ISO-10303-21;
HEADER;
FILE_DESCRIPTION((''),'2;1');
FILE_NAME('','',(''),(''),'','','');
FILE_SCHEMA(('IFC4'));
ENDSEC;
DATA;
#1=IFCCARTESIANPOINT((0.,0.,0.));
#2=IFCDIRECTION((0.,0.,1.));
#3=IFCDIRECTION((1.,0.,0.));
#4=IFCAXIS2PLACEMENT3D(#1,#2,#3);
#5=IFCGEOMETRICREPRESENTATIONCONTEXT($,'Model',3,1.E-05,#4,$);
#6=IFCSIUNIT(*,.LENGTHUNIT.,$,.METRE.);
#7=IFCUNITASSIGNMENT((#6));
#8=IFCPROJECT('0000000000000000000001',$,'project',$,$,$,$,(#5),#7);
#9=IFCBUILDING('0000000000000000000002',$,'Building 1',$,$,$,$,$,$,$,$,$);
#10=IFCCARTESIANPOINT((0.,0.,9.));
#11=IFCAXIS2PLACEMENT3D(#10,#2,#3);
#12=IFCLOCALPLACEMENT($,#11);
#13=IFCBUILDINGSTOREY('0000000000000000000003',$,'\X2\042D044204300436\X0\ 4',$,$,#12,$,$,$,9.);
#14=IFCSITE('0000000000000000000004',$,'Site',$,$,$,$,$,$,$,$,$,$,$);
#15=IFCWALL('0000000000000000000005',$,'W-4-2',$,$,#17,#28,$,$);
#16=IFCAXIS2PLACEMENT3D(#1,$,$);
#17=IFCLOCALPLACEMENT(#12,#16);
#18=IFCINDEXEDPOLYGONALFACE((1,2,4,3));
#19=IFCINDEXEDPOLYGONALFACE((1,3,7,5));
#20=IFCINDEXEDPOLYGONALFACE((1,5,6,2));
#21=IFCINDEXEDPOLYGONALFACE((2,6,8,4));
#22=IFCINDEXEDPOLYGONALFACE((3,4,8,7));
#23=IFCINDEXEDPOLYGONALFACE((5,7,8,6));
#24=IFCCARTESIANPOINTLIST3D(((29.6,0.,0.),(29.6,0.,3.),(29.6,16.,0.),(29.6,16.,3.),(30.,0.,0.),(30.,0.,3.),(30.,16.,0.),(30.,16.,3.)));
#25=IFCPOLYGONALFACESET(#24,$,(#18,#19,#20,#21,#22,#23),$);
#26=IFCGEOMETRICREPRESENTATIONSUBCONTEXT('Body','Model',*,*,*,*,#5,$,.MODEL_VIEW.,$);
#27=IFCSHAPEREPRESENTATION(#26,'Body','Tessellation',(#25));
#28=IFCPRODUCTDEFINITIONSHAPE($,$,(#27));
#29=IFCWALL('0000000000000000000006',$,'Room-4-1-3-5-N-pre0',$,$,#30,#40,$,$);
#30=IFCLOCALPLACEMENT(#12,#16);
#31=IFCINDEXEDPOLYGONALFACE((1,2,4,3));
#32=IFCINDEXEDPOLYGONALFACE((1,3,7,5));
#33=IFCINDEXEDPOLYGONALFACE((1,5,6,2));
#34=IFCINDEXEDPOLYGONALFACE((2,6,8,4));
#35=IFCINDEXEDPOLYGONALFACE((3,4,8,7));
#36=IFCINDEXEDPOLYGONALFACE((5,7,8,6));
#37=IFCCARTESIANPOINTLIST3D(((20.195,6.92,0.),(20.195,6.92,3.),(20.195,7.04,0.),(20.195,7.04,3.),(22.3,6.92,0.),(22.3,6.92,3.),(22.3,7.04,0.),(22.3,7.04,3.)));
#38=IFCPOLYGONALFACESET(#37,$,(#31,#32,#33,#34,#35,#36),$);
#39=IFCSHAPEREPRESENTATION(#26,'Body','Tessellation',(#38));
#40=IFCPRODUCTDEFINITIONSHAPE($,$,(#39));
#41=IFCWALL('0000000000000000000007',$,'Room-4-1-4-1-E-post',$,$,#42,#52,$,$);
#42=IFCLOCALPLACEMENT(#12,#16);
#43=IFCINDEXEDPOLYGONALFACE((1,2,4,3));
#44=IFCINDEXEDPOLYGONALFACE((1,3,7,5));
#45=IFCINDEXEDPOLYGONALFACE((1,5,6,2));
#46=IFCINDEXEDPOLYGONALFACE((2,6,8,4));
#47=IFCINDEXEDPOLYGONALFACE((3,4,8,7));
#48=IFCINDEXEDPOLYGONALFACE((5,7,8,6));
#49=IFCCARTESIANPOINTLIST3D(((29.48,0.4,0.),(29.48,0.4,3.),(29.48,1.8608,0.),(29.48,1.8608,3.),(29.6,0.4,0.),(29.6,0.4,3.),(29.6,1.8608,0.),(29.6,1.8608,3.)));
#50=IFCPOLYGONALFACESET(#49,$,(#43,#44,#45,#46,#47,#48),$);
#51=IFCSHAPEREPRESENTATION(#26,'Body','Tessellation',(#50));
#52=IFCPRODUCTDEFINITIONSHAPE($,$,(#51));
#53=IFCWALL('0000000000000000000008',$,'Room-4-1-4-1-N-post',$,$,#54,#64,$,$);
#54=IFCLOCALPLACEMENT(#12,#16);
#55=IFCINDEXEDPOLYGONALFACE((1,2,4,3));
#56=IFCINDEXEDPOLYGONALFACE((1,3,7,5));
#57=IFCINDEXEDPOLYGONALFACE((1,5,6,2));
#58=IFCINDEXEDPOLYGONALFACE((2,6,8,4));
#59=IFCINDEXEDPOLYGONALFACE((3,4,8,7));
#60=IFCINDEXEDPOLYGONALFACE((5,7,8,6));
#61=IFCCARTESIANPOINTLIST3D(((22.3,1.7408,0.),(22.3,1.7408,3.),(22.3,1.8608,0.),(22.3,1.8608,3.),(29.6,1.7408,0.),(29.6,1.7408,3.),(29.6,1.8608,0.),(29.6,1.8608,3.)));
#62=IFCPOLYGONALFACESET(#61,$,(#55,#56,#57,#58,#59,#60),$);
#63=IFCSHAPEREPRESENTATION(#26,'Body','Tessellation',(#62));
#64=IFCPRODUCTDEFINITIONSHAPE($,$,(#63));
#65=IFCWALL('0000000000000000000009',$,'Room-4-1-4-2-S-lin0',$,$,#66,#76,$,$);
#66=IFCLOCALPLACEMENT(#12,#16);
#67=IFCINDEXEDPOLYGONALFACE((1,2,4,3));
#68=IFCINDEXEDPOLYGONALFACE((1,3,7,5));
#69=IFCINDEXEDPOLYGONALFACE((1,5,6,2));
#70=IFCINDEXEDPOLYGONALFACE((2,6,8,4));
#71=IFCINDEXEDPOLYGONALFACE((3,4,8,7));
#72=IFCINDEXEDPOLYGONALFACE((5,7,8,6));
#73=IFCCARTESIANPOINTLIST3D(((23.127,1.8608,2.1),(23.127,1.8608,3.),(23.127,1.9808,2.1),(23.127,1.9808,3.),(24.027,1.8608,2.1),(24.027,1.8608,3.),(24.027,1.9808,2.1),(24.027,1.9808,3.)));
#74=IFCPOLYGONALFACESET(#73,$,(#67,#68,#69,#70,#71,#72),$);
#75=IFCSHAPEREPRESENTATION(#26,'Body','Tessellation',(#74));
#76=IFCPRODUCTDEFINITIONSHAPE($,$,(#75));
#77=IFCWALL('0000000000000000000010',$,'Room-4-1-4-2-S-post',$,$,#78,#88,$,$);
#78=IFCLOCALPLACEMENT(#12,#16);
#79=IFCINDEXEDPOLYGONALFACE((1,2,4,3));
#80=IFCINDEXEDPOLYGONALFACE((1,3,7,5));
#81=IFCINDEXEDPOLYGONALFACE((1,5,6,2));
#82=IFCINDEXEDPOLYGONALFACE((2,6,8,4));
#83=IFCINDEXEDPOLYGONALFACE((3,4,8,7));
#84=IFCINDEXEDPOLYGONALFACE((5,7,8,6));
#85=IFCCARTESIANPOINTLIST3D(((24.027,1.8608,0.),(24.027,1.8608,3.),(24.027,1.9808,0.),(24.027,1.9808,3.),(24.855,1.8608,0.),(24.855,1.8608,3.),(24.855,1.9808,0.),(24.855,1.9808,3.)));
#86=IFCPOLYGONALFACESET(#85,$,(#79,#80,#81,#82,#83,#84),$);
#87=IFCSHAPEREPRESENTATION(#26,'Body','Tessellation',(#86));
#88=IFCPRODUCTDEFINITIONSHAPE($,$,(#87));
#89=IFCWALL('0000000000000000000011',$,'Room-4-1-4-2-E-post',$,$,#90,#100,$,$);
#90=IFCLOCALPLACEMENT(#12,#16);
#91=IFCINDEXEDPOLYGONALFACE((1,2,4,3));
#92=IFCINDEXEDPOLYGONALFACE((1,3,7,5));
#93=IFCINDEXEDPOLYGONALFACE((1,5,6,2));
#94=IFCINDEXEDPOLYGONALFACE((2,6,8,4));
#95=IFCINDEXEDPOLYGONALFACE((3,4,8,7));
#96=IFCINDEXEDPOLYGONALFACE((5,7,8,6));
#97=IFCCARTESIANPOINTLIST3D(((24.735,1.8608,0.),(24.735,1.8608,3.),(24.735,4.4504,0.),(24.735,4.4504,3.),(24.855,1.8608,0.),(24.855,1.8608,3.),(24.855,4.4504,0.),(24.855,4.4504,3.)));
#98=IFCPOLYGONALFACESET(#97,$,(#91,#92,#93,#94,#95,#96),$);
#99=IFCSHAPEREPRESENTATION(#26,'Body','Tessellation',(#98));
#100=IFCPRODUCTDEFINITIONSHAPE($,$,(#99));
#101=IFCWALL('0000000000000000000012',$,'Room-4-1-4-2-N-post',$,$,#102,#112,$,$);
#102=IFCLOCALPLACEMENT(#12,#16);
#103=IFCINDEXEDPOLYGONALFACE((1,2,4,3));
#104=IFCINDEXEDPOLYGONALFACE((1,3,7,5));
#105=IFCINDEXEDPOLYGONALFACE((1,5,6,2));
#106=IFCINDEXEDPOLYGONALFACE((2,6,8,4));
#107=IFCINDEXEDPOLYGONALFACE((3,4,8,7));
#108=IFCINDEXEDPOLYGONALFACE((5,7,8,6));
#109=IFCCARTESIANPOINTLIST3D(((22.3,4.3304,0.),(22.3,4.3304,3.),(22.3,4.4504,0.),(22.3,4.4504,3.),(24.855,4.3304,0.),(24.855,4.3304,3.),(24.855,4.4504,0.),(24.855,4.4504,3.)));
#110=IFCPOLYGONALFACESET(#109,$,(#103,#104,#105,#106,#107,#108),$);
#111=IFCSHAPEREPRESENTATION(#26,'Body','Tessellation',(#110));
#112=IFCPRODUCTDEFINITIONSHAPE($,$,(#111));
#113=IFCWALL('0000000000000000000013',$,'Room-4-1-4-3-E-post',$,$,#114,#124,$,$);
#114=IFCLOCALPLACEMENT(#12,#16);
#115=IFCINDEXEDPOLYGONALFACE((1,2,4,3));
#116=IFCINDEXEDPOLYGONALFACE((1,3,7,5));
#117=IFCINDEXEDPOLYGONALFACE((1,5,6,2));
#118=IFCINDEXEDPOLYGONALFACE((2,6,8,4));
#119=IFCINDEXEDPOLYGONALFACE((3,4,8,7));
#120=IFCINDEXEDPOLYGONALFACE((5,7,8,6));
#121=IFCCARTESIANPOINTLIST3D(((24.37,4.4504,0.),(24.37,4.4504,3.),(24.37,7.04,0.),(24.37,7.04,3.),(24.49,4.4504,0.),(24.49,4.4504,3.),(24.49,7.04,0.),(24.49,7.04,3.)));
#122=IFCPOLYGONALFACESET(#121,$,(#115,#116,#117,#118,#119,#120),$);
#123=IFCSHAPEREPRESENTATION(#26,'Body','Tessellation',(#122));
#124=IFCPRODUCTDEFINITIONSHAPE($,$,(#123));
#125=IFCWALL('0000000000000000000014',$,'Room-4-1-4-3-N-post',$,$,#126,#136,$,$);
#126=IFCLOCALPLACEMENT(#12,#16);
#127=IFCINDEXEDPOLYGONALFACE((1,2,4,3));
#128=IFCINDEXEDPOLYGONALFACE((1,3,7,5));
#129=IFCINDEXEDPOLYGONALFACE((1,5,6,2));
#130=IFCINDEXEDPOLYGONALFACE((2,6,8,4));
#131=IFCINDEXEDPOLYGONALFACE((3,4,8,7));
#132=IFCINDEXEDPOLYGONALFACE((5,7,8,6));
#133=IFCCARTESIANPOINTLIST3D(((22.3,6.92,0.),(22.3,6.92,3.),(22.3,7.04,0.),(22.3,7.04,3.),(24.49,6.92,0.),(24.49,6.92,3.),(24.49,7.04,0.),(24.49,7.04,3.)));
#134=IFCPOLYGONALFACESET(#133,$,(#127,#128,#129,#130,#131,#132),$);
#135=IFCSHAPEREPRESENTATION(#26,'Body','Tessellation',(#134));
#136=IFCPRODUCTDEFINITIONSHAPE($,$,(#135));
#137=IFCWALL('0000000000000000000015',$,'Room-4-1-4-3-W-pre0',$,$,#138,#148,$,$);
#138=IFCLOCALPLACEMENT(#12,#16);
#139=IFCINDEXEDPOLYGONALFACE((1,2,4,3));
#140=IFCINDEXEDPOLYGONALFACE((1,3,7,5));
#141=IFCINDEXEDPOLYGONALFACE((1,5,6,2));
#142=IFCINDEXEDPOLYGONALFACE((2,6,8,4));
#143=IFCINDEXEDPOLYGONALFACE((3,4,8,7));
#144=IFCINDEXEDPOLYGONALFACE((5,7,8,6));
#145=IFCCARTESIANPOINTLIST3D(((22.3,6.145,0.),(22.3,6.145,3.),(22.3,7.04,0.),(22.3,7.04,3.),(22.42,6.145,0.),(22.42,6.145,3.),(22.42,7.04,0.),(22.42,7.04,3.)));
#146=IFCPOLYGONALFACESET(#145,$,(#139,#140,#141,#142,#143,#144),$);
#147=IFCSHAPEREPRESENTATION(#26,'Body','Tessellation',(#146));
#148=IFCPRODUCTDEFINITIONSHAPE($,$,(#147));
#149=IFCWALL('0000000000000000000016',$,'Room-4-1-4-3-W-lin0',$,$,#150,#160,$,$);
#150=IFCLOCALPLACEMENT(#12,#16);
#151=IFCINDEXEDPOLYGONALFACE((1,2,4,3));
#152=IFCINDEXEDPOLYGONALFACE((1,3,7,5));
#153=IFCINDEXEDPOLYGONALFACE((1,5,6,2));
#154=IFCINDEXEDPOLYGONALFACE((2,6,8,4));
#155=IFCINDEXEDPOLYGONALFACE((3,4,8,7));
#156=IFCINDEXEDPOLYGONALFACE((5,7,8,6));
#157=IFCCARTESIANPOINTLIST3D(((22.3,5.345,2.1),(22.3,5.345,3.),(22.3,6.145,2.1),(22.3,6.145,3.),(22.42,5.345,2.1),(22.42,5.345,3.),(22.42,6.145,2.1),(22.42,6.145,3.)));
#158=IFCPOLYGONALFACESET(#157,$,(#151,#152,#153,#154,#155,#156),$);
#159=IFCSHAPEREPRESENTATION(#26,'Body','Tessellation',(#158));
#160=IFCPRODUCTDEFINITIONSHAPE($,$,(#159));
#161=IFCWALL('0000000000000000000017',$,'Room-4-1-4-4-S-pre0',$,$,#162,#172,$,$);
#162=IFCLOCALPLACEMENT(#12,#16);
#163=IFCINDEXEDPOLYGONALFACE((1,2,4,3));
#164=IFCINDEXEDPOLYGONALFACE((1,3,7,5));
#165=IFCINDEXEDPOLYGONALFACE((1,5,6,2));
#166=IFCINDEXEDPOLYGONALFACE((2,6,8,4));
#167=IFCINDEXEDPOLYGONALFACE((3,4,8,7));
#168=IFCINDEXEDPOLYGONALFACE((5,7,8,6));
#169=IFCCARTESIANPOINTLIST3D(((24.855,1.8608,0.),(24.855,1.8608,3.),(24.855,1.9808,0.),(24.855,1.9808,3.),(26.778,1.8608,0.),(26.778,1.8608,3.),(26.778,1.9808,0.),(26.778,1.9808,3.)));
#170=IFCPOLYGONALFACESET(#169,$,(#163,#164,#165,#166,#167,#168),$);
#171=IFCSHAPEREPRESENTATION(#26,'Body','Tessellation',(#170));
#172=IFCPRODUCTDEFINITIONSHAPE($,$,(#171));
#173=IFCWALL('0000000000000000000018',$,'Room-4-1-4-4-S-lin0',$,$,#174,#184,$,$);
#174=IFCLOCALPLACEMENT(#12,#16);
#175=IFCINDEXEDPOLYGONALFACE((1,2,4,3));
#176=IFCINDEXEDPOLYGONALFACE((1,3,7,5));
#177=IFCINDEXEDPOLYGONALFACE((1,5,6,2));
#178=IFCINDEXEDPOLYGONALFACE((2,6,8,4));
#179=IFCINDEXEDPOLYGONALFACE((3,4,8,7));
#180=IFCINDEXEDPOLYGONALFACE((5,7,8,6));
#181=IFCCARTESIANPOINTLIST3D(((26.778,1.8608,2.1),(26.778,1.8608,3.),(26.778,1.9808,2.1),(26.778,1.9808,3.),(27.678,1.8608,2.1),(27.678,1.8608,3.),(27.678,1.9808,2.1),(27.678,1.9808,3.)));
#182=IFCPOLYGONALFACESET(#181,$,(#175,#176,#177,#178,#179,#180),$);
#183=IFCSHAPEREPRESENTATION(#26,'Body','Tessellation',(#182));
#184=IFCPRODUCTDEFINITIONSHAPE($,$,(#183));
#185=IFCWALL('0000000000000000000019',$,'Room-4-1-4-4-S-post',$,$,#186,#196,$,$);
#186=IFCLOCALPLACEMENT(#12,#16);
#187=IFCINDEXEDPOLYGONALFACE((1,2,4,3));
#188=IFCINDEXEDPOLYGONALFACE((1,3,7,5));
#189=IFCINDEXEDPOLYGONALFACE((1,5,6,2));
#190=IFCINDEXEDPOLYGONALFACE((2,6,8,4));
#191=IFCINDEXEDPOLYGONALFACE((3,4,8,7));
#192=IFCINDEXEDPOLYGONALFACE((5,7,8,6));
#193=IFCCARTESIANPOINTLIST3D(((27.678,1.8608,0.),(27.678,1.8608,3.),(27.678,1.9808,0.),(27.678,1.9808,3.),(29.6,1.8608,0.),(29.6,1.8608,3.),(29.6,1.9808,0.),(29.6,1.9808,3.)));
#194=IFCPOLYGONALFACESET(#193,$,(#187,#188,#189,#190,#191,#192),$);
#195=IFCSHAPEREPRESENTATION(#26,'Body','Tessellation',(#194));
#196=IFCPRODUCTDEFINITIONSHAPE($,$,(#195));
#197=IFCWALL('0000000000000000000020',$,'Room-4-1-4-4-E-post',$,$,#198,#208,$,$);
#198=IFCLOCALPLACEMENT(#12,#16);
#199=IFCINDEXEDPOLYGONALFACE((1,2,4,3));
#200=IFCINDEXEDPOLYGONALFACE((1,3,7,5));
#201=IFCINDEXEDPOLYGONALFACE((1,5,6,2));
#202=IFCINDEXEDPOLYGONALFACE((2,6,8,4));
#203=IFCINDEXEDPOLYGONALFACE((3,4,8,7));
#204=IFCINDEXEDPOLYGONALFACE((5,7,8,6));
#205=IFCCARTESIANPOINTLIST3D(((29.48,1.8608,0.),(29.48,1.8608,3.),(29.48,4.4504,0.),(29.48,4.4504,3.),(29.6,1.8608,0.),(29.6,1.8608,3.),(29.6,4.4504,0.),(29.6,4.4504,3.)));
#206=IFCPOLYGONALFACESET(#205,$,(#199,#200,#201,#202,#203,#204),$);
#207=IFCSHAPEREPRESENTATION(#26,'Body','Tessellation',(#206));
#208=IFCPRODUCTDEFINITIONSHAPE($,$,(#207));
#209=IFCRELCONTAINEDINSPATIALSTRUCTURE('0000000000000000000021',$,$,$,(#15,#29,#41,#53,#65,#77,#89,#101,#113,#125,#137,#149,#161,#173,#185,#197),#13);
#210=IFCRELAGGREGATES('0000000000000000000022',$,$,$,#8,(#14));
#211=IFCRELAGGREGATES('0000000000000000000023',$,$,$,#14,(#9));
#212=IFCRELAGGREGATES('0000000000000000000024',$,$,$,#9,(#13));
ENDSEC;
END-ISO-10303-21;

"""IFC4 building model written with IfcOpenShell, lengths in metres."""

from ifc_helpers import new_model, si_unit, frame, origin_with_axes, place, context, subcontext, project, spatial, indexed_curve, outline, extrude, element, save


model = new_model("IFC4")

# Units and contexts
model_context = context("Model", 3, precision=1e-05, world=origin_with_axes())
body_context = subcontext(model_context, "Body", "Model", "MODEL_VIEW")
ifc_project = project(units=[si_unit("LENGTHUNIT", "METRE")], contexts=[model_context])

# Site, building, storey
site = spatial("IfcSite", under=ifc_project, Name="Site")
building = spatial("IfcBuilding", under=site, Name="Building 1")
storey_placement = place(None, frame((0.0, 0.0, 9.0), z_axis=(0.0, 0.0, 1.0), x_axis=(1.0, 0.0, 0.0)))
storey = spatial("IfcBuildingStorey", under=building, at=storey_placement, Name="Этаж 4", Elevation=9.0)

# Walls
wall_1_placement = place(storey_placement, frame((30.0, 0.0, 0.0), z_axis=(0.0, 0.0, 1.0), x_axis=(0.0, 1.0, 0.0)))
element("IfcWall", 1, at=wall_1_placement, inside=storey, Name="W-4-2", context=body_context, shape_type="SweptSolid", body=[
    extrude(outline(indexed_curve([(0.0, 0.0), (0.0, 0.4), (16.0, 0.4), (16.0, 0.0), (0.0, 0.0)], self_intersect=False)), origin_with_axes(), (0.0, 0.0, 1.0), 3.0),
])
wall_2_placement = place(storey_placement, frame((22.3, 7.04, 0.0), z_axis=(0.0, 0.0, 1.0), x_axis=(-1.0, 0.0, 0.0)))
element("IfcWall", 2, at=wall_2_placement, inside=storey, Name="Room-4-1-3-5-N-pre0", context=body_context, shape_type="SweptSolid", body=[
    extrude(outline(indexed_curve([(0.0, 0.0), (0.0, 0.12), (2.105, 0.12), (2.105, 0.0), (0.0, 0.0)], self_intersect=False)), origin_with_axes(), (0.0, 0.0, 1.0), 3.0),
])
wall_3_placement = place(storey_placement, frame((29.6, 0.4, 0.0), z_axis=(0.0, 0.0, 1.0), x_axis=(0.0, 1.0, 0.0)))
element("IfcWall", 3, at=wall_3_placement, inside=storey, Name="Room-4-1-4-1-E-post", context=body_context, shape_type="SweptSolid", body=[
    extrude(outline(indexed_curve([(0.0, 0.0), (0.0, 0.12), (1.4608, 0.12), (1.4608, 0.0), (0.0, 0.0)], self_intersect=False)), origin_with_axes(), (0.0, 0.0, 1.0), 3.0),
])
wall_4_placement = place(storey_placement, frame((29.6, 1.8608, 0.0), z_axis=(0.0, 0.0, 1.0), x_axis=(-1.0, 0.0, 0.0)))
element("IfcWall", 4, at=wall_4_placement, inside=storey, Name="Room-4-1-4-1-N-post", context=body_context, shape_type="SweptSolid", body=[
    extrude(outline(indexed_curve([(0.0, 0.0), (0.0, 0.12), (7.3, 0.12), (7.3, 0.0), (0.0, 0.0)], self_intersect=False)), origin_with_axes(), (0.0, 0.0, 1.0), 3.0),
])
wall_5_placement = place(storey_placement, frame((23.127, 1.8608, 2.1), z_axis=(0.0, 0.0, 1.0), x_axis=(1.0, 0.0, 0.0)))
element("IfcWall", 5, at=wall_5_placement, inside=storey, Name="Room-4-1-4-2-S-lin0", context=body_context, shape_type="SweptSolid", body=[
    extrude(outline(indexed_curve([(0.0, 0.0), (0.0, 0.12), (0.9, 0.12), (0.9, 0.0), (0.0, 0.0)], self_intersect=False)), origin_with_axes(), (0.0, 0.0, 1.0), 0.9),
])
wall_6_placement = place(storey_placement, frame((24.027, 1.8608, 0.0), z_axis=(0.0, 0.0, 1.0), x_axis=(1.0, 0.0, 0.0)))
element("IfcWall", 6, at=wall_6_placement, inside=storey, Name="Room-4-1-4-2-S-post", context=body_context, shape_type="SweptSolid", body=[
    extrude(outline(indexed_curve([(0.0, 0.0), (0.0, 0.12), (0.828, 0.12), (0.828, 0.0), (0.0, 0.0)], self_intersect=False)), origin_with_axes(), (0.0, 0.0, 1.0), 3.0),
])
wall_7_placement = place(storey_placement, frame((24.855, 1.8608, 0.0), z_axis=(0.0, 0.0, 1.0), x_axis=(0.0, 1.0, 0.0)))
element("IfcWall", 7, at=wall_7_placement, inside=storey, Name="Room-4-1-4-2-E-post", context=body_context, shape_type="SweptSolid", body=[
    extrude(outline(indexed_curve([(0.0, 0.0), (0.0, 0.12), (2.5896, 0.12), (2.5896, 0.0), (0.0, 0.0)], self_intersect=False)), origin_with_axes(), (0.0, 0.0, 1.0), 3.0),
])
wall_8_placement = place(storey_placement, frame((24.855, 4.4504, 0.0), z_axis=(0.0, 0.0, 1.0), x_axis=(-1.0, 0.0, 0.0)))
element("IfcWall", 8, at=wall_8_placement, inside=storey, Name="Room-4-1-4-2-N-post", context=body_context, shape_type="SweptSolid", body=[
    extrude(outline(indexed_curve([(0.0, 0.0), (0.0, 0.12), (2.555, 0.12), (2.555, 0.0), (0.0, 0.0)], self_intersect=False)), origin_with_axes(), (0.0, 0.0, 1.0), 3.0),
])
wall_9_placement = place(storey_placement, frame((24.49, 4.4504, 0.0), z_axis=(0.0, 0.0, 1.0), x_axis=(0.0, 1.0, 0.0)))
element("IfcWall", 9, at=wall_9_placement, inside=storey, Name="Room-4-1-4-3-E-post", context=body_context, shape_type="SweptSolid", body=[
    extrude(outline(indexed_curve([(0.0, 0.0), (0.0, 0.12), (2.5896, 0.12), (2.5896, 0.0), (0.0, 0.0)], self_intersect=False)), origin_with_axes(), (0.0, 0.0, 1.0), 3.0),
])
wall_10_placement = place(storey_placement, frame((24.49, 7.04, 0.0), z_axis=(0.0, 0.0, 1.0), x_axis=(-1.0, 0.0, 0.0)))
element("IfcWall", 10, at=wall_10_placement, inside=storey, Name="Room-4-1-4-3-N-post", context=body_context, shape_type="SweptSolid", body=[
    extrude(outline(indexed_curve([(0.0, 0.0), (0.0, 0.12), (2.19, 0.12), (2.19, 0.0), (0.0, 0.0)], self_intersect=False)), origin_with_axes(), (0.0, 0.0, 1.0), 3.0),
])
wall_11_placement = place(storey_placement, frame((22.3, 7.04, 0.0), z_axis=(0.0, 0.0, 1.0), x_axis=(0.0, -1.0, 0.0)))
element("IfcWall", 11, at=wall_11_placement, inside=storey, Name="Room-4-1-4-3-W-pre0", context=body_context, shape_type="SweptSolid", body=[
    extrude(outline(indexed_curve([(0.0, 0.0), (0.0, 0.12), (0.895, 0.12), (0.895, 0.0), (0.0, 0.0)], self_intersect=False)), origin_with_axes(), (0.0, 0.0, 1.0), 3.0),
])
wall_12_placement = place(storey_placement, frame((22.3, 6.145, 2.1), z_axis=(0.0, 0.0, 1.0), x_axis=(0.0, -1.0, 0.0)))
element("IfcWall", 12, at=wall_12_placement, inside=storey, Name="Room-4-1-4-3-W-lin0", context=body_context, shape_type="SweptSolid", body=[
    extrude(outline(indexed_curve([(0.0, 0.0), (0.0, 0.12), (0.8, 0.12), (0.8, 0.0), (0.0, 0.0)], self_intersect=False)), origin_with_axes(), (0.0, 0.0, 1.0), 0.9),
])
wall_13_placement = place(storey_placement, frame((24.855, 1.8608, 0.0), z_axis=(0.0, 0.0, 1.0), x_axis=(1.0, 0.0, 0.0)))
element("IfcWall", 13, at=wall_13_placement, inside=storey, Name="Room-4-1-4-4-S-pre0", context=body_context, shape_type="SweptSolid", body=[
    extrude(outline(indexed_curve([(0.0, 0.0), (0.0, 0.12), (1.923, 0.12), (1.923, 0.0), (0.0, 0.0)], self_intersect=False)), origin_with_axes(), (0.0, 0.0, 1.0), 3.0),
])
wall_14_placement = place(storey_placement, frame((26.778, 1.8608, 2.1), z_axis=(0.0, 0.0, 1.0), x_axis=(1.0, 0.0, 0.0)))
element("IfcWall", 14, at=wall_14_placement, inside=storey, Name="Room-4-1-4-4-S-lin0", context=body_context, shape_type="SweptSolid", body=[
    extrude(outline(indexed_curve([(0.0, 0.0), (0.0, 0.12), (0.9, 0.12), (0.9, 0.0), (0.0, 0.0)], self_intersect=False)), origin_with_axes(), (0.0, 0.0, 1.0), 0.9),
])
wall_15_placement = place(storey_placement, frame((27.678, 1.8608, 0.0), z_axis=(0.0, 0.0, 1.0), x_axis=(1.0, 0.0, 0.0)))
element("IfcWall", 15, at=wall_15_placement, inside=storey, Name="Room-4-1-4-4-S-post", context=body_context, shape_type="SweptSolid", body=[
    extrude(outline(indexed_curve([(0.0, 0.0), (0.0, 0.12), (1.922, 0.12), (1.922, 0.0), (0.0, 0.0)], self_intersect=False)), origin_with_axes(), (0.0, 0.0, 1.0), 3.0),
])
wall_16_placement = place(storey_placement, frame((29.6, 1.8608, 0.0), z_axis=(0.0, 0.0, 1.0), x_axis=(0.0, 1.0, 0.0)))
element("IfcWall", 16, at=wall_16_placement, inside=storey, Name="Room-4-1-4-4-E-post", context=body_context, shape_type="SweptSolid", body=[
    extrude(outline(indexed_curve([(0.0, 0.0), (0.0, 0.12), (2.5896, 0.12), (2.5896, 0.0), (0.0, 0.0)], self_intersect=False)), origin_with_axes(), (0.0, 0.0, 1.0), 3.0),
])

save(model, "model.ifc")
